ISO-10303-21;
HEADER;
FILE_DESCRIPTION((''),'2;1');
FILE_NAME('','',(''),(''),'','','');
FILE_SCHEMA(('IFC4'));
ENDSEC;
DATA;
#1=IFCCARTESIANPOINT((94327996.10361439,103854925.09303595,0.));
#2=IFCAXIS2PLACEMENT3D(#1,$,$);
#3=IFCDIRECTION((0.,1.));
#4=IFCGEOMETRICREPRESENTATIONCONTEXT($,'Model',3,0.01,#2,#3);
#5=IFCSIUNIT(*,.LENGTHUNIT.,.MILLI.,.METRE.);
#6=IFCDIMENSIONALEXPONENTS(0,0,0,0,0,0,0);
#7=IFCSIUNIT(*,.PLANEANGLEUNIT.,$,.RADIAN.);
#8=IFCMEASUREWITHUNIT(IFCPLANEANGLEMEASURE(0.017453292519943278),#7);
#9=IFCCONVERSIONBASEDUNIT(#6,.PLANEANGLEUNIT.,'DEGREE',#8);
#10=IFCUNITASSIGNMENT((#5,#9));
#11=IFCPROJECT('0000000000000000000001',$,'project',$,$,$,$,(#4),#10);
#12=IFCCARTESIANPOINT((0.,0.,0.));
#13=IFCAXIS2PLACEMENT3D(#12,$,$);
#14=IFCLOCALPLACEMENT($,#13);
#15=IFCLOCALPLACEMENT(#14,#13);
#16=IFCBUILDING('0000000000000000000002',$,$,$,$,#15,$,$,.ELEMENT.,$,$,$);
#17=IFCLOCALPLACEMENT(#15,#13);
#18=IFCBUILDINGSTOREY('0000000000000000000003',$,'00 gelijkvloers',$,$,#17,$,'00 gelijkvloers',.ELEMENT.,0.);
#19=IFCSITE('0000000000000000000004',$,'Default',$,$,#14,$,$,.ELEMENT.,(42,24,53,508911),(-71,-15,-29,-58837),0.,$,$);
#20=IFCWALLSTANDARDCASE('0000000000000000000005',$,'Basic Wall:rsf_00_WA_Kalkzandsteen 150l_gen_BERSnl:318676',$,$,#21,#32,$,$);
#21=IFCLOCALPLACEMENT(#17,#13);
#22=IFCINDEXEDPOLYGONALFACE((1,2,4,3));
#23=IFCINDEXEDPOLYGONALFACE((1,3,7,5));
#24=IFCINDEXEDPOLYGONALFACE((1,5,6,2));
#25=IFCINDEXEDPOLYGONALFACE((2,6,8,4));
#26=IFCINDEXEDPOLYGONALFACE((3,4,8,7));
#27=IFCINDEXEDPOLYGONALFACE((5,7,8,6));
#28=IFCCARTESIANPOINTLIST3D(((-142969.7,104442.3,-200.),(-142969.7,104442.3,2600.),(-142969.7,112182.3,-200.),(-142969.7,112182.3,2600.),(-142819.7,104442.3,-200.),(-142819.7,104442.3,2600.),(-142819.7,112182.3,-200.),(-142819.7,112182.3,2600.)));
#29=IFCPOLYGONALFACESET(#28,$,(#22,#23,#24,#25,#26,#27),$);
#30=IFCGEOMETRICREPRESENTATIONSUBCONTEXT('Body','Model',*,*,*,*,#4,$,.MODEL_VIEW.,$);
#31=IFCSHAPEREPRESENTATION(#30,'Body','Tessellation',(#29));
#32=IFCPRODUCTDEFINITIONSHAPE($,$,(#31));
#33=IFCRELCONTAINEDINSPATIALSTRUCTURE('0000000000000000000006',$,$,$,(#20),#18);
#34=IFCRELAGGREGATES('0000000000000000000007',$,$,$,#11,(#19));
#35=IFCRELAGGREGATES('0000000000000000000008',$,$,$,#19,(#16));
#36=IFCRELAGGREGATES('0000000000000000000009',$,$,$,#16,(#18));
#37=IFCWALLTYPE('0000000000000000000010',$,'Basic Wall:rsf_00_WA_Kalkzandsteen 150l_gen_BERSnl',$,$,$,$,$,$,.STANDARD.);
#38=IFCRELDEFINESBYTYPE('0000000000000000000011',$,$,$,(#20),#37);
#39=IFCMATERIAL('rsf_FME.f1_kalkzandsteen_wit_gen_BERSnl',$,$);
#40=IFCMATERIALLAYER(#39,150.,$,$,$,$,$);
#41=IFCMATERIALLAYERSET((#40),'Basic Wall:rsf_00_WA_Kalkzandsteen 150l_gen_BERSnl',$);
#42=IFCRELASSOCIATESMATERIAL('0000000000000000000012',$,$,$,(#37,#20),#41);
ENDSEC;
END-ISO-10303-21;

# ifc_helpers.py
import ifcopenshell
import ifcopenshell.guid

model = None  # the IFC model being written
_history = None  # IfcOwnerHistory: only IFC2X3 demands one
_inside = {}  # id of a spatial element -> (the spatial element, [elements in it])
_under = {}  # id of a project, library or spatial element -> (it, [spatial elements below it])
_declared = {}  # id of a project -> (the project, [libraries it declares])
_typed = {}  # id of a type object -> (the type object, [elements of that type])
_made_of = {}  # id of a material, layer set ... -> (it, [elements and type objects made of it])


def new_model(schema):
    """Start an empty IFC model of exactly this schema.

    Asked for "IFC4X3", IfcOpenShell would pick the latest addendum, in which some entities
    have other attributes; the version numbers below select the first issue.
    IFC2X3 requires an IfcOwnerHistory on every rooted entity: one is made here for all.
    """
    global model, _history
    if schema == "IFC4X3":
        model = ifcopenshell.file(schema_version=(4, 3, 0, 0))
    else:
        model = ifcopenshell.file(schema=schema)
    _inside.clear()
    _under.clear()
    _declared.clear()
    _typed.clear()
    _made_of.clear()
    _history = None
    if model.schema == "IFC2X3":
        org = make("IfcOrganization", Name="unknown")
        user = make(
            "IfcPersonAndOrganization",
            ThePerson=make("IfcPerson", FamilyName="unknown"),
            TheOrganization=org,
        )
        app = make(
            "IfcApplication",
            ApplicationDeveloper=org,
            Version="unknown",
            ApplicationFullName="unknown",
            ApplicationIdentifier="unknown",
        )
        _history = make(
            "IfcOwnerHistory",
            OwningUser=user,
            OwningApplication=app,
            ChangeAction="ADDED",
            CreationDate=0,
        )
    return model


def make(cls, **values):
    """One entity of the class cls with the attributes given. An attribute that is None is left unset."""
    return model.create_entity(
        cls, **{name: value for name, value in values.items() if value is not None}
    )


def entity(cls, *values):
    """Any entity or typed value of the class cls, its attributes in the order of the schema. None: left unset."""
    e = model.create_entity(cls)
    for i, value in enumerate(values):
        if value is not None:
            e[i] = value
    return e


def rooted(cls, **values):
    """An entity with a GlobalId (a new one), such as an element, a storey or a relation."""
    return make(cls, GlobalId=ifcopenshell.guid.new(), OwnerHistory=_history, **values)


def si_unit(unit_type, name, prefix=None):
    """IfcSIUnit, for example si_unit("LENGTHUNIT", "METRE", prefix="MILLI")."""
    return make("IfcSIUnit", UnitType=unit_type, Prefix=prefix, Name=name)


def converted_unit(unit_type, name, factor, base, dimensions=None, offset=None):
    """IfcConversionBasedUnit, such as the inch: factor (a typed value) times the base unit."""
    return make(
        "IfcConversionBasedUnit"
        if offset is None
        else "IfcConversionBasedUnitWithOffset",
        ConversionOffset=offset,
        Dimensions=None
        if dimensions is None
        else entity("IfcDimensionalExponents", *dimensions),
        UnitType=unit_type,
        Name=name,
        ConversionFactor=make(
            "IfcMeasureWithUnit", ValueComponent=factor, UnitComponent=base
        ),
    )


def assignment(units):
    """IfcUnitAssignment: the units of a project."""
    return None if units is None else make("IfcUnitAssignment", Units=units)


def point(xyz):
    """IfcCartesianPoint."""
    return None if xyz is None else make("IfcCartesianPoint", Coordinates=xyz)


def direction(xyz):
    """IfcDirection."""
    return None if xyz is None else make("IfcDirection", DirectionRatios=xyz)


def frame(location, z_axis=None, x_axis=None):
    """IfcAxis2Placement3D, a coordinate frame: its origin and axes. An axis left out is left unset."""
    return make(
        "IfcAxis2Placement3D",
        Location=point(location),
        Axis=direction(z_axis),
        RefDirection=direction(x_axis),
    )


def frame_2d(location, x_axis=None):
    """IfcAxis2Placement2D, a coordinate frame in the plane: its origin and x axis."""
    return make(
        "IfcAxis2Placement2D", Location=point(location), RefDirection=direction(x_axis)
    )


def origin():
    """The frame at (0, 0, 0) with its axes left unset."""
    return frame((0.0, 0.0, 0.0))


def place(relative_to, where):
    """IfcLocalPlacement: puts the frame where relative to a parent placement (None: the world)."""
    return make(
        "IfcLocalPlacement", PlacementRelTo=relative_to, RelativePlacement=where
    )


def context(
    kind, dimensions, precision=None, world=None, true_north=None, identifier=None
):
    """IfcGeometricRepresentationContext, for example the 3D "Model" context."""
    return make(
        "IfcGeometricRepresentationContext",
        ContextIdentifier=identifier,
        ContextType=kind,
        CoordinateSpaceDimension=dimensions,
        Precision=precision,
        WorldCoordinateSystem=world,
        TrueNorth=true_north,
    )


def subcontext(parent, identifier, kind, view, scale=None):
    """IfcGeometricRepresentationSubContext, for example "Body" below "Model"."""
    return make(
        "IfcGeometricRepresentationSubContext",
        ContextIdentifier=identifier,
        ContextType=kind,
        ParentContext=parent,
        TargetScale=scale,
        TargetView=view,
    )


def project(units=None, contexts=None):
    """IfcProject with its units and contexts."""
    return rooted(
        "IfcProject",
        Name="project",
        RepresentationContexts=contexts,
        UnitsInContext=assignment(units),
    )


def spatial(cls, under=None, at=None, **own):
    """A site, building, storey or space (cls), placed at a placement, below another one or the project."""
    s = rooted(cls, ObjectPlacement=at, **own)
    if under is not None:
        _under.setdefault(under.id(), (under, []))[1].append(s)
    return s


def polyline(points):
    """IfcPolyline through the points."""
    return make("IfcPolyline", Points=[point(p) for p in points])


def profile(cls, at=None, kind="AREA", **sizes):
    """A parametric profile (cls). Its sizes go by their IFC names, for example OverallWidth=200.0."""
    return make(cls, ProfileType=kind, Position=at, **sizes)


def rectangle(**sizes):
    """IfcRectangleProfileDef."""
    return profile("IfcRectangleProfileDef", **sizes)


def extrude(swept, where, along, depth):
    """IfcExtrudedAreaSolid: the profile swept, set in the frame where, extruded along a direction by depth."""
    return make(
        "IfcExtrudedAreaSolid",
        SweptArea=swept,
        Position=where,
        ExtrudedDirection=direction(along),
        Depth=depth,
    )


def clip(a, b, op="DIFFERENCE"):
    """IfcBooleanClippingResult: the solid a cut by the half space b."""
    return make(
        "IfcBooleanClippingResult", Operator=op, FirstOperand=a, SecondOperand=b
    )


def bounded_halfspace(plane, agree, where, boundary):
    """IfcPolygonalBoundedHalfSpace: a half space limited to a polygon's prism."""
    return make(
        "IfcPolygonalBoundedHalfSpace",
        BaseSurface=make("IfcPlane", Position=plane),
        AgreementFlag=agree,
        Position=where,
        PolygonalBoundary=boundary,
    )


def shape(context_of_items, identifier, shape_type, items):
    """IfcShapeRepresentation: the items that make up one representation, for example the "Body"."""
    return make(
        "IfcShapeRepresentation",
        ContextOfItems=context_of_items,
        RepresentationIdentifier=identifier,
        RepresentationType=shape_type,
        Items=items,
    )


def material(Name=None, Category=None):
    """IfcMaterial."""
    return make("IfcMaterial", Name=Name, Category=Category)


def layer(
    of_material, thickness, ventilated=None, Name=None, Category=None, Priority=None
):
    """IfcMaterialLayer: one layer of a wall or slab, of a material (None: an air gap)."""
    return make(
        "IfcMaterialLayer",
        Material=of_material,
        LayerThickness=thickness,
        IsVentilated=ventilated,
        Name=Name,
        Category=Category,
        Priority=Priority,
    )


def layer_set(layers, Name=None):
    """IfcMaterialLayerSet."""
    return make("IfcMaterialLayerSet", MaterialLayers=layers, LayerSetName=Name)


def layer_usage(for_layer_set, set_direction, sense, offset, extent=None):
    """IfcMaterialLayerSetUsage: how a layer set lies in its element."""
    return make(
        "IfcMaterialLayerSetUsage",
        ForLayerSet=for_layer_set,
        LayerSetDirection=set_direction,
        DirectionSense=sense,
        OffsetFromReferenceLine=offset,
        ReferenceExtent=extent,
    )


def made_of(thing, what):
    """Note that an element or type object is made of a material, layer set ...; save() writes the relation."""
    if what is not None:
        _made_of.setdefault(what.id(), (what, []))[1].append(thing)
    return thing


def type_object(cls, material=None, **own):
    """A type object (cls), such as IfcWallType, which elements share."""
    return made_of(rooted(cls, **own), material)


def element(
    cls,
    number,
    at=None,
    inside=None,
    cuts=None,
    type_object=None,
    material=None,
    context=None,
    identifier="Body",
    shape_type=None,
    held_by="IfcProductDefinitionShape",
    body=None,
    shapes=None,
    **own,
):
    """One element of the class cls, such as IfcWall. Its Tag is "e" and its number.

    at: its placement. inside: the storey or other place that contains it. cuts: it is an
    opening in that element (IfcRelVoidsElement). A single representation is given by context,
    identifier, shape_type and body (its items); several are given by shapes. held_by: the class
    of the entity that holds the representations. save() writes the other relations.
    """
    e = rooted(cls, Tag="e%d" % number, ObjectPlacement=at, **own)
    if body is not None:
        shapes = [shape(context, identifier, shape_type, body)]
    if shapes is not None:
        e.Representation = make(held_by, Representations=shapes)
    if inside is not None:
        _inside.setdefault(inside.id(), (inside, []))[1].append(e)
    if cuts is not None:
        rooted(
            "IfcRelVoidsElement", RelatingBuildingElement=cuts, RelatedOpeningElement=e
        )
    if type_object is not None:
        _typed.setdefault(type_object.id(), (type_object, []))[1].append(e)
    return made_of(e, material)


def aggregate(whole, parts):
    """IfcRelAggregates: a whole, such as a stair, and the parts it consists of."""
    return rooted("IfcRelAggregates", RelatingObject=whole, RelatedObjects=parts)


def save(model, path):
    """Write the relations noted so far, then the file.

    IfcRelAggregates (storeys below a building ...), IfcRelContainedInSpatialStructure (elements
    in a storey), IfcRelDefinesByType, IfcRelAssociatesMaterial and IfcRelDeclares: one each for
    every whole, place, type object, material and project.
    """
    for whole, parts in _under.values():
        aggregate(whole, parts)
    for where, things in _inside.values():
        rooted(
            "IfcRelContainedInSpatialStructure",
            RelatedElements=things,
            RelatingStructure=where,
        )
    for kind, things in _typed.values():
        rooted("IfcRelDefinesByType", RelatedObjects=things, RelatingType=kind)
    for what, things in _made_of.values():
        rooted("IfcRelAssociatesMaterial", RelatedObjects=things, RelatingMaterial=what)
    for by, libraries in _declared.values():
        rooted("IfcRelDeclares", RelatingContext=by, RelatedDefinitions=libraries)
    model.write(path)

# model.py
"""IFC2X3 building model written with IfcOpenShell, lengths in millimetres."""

from ifc_helpers import new_model, entity, si_unit, converted_unit, direction, frame, frame_2d, origin, place, context, subcontext, project, spatial, polyline, rectangle, extrude, clip, bounded_halfspace, material, layer, layer_set, layer_usage, type_object, element, save


model = new_model("IFC2X3")

# Units and contexts
model_context = context("Model", 3, precision=0.01, world=frame((94327996.10361439, 103854925.09303595, 0.0)), true_north=direction((0.0, 1.0)))
body_context = subcontext(model_context, "Body", "Model", "MODEL_VIEW")
ifc_project = project(units=[si_unit("LENGTHUNIT", "METRE", prefix="MILLI"), converted_unit("PLANEANGLEUNIT", "DEGREE", entity("IfcPlaneAngleMeasure", 0.017453292519943278), si_unit("PLANEANGLEUNIT", "RADIAN"), dimensions=[0, 0, 0, 0, 0, 0, 0])], contexts=[model_context])

# Site, building, storey
site_placement = place(None, origin())
site = spatial("IfcSite", under=ifc_project, at=site_placement, Name="Default", CompositionType="ELEMENT", RefLatitude=(42, 24, 53, 508911), RefLongitude=(-71, -15, -29, -58837), RefElevation=0.0)
building_placement = place(site_placement, origin())
building = spatial("IfcBuilding", under=site, at=building_placement, CompositionType="ELEMENT")
storey_placement = place(building_placement, origin())
storey = spatial("IfcBuildingStorey", under=building, at=storey_placement, Name="00 gelijkvloers", LongName="00 gelijkvloers", CompositionType="ELEMENT", Elevation=0.0)

# Shared definitions
ifc_material_1 = material(Name="rsf_FME.f1_kalkzandsteen_wit_gen_BERSnl")
ifc_layer_1 = layer(ifc_material_1, 150.0)
ifc_layer_set_1 = layer_set([ifc_layer_1], Name="Basic Wall:rsf_00_WA_Kalkzandsteen 150l_gen_BERSnl")
wall_type_1 = type_object("IfcWallType", Name="Basic Wall:rsf_00_WA_Kalkzandsteen 150l_gen_BERSnl", PredefinedType="STANDARD", material=ifc_layer_set_1)

# Wall
ifc_layer_usage_1 = layer_usage(ifc_layer_set_1, "AXIS2", "NEGATIVE", 75.0)
wall_1_placement = place(storey_placement, frame((-142894.7, 104442.3, -200.0), z_axis=(0.0, 0.0, 1.0), x_axis=(0.0, 1.0, 0.0)))
element("IfcWallStandardCase", 1, at=wall_1_placement, inside=storey, type_object=wall_type_1, material=ifc_layer_usage_1, Name="Basic Wall:rsf_00_WA_Kalkzandsteen 150l_gen_BERSnl:318676", context=body_context, shape_type="Clipping", body=[
    clip(extrude(rectangle(XDim=7740.0, YDim=150.0, at=frame_2d((3870.0, 0.0), x_axis=(-1.0, 0.0))), origin(), (0.0, 0.0, 1.0), 2800.0), bounded_halfspace(frame((0.0, -75.0, 2800.0), z_axis=(0.0, 0.0, -1.0), x_axis=(1.0, 0.0, 0.0)), True, frame((0.0, -75.0, 2800.0)), polyline([(0.0, 0.0), (7740.0, 0.0), (7740.0, 150.0), (0.0, 150.0), (0.0, 0.0)]))),
])

save(model, "model.ifc")
